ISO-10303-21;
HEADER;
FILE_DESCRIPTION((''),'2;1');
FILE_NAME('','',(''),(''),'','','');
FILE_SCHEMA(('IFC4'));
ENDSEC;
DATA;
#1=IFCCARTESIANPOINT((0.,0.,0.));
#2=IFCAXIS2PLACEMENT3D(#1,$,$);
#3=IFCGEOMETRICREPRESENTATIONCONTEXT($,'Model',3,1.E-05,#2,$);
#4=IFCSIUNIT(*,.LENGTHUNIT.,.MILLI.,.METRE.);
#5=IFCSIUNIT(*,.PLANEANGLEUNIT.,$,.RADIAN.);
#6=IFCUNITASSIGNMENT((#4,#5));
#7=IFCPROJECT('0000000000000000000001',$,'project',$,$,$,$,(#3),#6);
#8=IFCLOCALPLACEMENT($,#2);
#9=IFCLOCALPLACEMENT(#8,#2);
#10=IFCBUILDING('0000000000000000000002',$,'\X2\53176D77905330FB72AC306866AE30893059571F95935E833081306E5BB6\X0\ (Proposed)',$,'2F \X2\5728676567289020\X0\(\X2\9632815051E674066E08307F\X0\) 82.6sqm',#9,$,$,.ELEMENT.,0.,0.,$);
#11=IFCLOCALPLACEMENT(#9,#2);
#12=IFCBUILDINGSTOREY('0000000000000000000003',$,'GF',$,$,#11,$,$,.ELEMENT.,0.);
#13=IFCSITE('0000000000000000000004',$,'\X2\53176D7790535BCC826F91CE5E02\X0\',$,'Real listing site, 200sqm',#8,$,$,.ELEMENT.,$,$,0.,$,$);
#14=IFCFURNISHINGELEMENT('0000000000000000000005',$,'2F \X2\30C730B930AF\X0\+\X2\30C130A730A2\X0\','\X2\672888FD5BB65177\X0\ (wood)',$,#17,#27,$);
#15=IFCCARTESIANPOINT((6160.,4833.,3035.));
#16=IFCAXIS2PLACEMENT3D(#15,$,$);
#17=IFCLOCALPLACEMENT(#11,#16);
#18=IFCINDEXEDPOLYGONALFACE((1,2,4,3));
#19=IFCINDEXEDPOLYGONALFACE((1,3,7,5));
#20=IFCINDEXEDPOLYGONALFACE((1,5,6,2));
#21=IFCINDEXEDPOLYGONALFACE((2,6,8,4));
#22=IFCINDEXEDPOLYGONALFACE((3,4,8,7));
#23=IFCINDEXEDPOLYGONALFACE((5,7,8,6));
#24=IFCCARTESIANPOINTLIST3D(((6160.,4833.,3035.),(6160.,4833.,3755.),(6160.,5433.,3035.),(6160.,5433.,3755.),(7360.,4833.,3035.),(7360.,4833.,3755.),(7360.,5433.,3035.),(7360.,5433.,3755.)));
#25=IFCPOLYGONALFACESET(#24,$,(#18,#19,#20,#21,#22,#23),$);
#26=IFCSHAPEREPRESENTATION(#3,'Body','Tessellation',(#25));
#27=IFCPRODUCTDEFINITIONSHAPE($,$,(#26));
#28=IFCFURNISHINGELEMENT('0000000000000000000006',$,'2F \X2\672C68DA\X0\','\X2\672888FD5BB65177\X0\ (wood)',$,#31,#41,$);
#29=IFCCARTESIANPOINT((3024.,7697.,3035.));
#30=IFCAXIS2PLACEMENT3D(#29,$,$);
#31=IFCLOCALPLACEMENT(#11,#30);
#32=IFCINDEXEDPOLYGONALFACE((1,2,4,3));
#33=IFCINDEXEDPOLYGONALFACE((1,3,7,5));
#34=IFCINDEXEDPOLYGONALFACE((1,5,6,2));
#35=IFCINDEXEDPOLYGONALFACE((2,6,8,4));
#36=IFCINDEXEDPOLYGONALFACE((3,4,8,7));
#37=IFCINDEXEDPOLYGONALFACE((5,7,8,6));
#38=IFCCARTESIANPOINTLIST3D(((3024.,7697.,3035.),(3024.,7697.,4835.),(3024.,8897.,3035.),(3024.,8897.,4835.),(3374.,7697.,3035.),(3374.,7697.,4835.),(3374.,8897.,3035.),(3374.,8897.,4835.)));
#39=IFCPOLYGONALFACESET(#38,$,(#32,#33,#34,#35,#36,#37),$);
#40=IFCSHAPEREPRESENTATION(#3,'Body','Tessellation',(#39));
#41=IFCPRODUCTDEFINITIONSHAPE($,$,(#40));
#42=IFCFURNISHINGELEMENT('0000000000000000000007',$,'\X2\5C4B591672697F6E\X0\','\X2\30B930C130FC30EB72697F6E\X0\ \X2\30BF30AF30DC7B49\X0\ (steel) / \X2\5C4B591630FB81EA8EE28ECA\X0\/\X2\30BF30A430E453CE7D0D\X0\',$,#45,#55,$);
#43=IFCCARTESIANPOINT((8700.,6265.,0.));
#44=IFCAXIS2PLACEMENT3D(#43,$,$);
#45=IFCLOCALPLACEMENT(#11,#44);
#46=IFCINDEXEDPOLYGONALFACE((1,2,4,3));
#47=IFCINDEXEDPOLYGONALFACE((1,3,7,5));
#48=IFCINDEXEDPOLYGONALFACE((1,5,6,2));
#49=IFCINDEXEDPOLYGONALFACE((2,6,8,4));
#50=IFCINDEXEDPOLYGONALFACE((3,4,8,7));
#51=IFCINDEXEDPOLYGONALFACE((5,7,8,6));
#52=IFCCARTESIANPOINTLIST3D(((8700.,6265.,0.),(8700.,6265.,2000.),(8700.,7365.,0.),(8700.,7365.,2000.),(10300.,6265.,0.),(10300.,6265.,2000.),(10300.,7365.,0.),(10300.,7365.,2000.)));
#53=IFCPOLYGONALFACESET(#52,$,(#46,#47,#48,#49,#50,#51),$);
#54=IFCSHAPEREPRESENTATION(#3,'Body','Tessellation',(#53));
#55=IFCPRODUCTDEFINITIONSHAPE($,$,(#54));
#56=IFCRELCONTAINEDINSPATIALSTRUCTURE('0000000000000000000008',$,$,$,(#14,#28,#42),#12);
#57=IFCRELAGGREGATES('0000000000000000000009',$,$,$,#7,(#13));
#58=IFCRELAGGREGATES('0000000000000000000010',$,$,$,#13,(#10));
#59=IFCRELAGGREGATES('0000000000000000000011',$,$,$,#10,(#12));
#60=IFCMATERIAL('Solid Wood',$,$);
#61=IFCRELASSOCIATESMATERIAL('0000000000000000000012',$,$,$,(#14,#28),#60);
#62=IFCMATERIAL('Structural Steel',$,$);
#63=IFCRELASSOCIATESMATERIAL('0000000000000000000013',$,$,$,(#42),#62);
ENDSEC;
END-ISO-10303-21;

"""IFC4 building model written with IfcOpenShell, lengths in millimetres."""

from ifc_helpers import new_model, si_unit, frame, frame_2d, origin, place, context, project, spatial, rectangle, extrude, material, element, save


model = new_model("IFC4")

# Units and contexts
model_context = context("Model", 3, precision=1e-05, world=origin())
ifc_project = project(units=[si_unit("LENGTHUNIT", "METRE", prefix="MILLI"), si_unit("PLANEANGLEUNIT", "RADIAN")], contexts=[model_context])

# Site, building, storey
site_placement = place(None, origin())
site = spatial("IfcSite", under=ifc_project, at=site_placement, Name="北海道富良野市", ObjectType="Real listing site, 200sqm", CompositionType="ELEMENT", RefElevation=0.0)
building_placement = place(site_placement, origin())
building = spatial("IfcBuilding", under=site, at=building_placement, Name="北海道・犬と暮らす土間広めの家 (Proposed)", ObjectType="2F 在来木造(防腐処理済み) 82.6sqm", CompositionType="ELEMENT", ElevationOfRefHeight=0.0, ElevationOfTerrain=0.0)
storey_placement = place(building_placement, origin())
storey = spatial("IfcBuildingStorey", under=building, at=storey_placement, Name="GF", CompositionType="ELEMENT", Elevation=0.0)

# Shared definitions
ifc_material_1 = material(Name="Solid Wood")

# Shared definitions
ifc_material_2 = material(Name="Structural Steel")

# Furnishing elements
furnishing_1_placement = place(storey_placement, frame((6160.0, 4833.0, 3035.0)))
element("IfcFurnishingElement", 1, at=furnishing_1_placement, inside=storey, material=ifc_material_1, Name="2F デスク+チェア", Description="木製家具 (wood)", context=model_context, shape_type="SweptSolid", body=[
    extrude(rectangle(XDim=1200.0, YDim=600.0, at=frame_2d((600.0, 300.0))), frame((6160.0, 4833.0, 3035.0)), (0.0, 0.0, 1.0), 720.0),
])
furnishing_2_placement = place(storey_placement, frame((3024.0, 7697.0, 3035.0)))
element("IfcFurnishingElement", 2, at=furnishing_2_placement, inside=storey, material=ifc_material_1, Name="2F 本棚", Description="木製家具 (wood)", context=model_context, shape_type="SweptSolid", body=[
    extrude(rectangle(XDim=350.0, YDim=1200.0, at=frame_2d((175.0, 600.0))), frame((3024.0, 7697.0, 3035.0)), (0.0, 0.0, 1.0), 1800.0),
])
furnishing_3_placement = place(storey_placement, frame((8700.0, 6265.0, 0.0)))
element("IfcFurnishingElement", 3, at=furnishing_3_placement, inside=storey, material=ifc_material_2, Name="屋外物置", Description="スチール物置 タクボ等 (steel) / 屋外・自転車/タイヤ収納", context=model_context, shape_type="SweptSolid", body=[
    extrude(rectangle(XDim=1600.0, YDim=1100.0, at=frame_2d((800.0, 550.0))), frame((8700.0, 6265.0, 0.0)), (0.0, 0.0, 1.0), 2000.0),
])

save(model, "model.ifc")
